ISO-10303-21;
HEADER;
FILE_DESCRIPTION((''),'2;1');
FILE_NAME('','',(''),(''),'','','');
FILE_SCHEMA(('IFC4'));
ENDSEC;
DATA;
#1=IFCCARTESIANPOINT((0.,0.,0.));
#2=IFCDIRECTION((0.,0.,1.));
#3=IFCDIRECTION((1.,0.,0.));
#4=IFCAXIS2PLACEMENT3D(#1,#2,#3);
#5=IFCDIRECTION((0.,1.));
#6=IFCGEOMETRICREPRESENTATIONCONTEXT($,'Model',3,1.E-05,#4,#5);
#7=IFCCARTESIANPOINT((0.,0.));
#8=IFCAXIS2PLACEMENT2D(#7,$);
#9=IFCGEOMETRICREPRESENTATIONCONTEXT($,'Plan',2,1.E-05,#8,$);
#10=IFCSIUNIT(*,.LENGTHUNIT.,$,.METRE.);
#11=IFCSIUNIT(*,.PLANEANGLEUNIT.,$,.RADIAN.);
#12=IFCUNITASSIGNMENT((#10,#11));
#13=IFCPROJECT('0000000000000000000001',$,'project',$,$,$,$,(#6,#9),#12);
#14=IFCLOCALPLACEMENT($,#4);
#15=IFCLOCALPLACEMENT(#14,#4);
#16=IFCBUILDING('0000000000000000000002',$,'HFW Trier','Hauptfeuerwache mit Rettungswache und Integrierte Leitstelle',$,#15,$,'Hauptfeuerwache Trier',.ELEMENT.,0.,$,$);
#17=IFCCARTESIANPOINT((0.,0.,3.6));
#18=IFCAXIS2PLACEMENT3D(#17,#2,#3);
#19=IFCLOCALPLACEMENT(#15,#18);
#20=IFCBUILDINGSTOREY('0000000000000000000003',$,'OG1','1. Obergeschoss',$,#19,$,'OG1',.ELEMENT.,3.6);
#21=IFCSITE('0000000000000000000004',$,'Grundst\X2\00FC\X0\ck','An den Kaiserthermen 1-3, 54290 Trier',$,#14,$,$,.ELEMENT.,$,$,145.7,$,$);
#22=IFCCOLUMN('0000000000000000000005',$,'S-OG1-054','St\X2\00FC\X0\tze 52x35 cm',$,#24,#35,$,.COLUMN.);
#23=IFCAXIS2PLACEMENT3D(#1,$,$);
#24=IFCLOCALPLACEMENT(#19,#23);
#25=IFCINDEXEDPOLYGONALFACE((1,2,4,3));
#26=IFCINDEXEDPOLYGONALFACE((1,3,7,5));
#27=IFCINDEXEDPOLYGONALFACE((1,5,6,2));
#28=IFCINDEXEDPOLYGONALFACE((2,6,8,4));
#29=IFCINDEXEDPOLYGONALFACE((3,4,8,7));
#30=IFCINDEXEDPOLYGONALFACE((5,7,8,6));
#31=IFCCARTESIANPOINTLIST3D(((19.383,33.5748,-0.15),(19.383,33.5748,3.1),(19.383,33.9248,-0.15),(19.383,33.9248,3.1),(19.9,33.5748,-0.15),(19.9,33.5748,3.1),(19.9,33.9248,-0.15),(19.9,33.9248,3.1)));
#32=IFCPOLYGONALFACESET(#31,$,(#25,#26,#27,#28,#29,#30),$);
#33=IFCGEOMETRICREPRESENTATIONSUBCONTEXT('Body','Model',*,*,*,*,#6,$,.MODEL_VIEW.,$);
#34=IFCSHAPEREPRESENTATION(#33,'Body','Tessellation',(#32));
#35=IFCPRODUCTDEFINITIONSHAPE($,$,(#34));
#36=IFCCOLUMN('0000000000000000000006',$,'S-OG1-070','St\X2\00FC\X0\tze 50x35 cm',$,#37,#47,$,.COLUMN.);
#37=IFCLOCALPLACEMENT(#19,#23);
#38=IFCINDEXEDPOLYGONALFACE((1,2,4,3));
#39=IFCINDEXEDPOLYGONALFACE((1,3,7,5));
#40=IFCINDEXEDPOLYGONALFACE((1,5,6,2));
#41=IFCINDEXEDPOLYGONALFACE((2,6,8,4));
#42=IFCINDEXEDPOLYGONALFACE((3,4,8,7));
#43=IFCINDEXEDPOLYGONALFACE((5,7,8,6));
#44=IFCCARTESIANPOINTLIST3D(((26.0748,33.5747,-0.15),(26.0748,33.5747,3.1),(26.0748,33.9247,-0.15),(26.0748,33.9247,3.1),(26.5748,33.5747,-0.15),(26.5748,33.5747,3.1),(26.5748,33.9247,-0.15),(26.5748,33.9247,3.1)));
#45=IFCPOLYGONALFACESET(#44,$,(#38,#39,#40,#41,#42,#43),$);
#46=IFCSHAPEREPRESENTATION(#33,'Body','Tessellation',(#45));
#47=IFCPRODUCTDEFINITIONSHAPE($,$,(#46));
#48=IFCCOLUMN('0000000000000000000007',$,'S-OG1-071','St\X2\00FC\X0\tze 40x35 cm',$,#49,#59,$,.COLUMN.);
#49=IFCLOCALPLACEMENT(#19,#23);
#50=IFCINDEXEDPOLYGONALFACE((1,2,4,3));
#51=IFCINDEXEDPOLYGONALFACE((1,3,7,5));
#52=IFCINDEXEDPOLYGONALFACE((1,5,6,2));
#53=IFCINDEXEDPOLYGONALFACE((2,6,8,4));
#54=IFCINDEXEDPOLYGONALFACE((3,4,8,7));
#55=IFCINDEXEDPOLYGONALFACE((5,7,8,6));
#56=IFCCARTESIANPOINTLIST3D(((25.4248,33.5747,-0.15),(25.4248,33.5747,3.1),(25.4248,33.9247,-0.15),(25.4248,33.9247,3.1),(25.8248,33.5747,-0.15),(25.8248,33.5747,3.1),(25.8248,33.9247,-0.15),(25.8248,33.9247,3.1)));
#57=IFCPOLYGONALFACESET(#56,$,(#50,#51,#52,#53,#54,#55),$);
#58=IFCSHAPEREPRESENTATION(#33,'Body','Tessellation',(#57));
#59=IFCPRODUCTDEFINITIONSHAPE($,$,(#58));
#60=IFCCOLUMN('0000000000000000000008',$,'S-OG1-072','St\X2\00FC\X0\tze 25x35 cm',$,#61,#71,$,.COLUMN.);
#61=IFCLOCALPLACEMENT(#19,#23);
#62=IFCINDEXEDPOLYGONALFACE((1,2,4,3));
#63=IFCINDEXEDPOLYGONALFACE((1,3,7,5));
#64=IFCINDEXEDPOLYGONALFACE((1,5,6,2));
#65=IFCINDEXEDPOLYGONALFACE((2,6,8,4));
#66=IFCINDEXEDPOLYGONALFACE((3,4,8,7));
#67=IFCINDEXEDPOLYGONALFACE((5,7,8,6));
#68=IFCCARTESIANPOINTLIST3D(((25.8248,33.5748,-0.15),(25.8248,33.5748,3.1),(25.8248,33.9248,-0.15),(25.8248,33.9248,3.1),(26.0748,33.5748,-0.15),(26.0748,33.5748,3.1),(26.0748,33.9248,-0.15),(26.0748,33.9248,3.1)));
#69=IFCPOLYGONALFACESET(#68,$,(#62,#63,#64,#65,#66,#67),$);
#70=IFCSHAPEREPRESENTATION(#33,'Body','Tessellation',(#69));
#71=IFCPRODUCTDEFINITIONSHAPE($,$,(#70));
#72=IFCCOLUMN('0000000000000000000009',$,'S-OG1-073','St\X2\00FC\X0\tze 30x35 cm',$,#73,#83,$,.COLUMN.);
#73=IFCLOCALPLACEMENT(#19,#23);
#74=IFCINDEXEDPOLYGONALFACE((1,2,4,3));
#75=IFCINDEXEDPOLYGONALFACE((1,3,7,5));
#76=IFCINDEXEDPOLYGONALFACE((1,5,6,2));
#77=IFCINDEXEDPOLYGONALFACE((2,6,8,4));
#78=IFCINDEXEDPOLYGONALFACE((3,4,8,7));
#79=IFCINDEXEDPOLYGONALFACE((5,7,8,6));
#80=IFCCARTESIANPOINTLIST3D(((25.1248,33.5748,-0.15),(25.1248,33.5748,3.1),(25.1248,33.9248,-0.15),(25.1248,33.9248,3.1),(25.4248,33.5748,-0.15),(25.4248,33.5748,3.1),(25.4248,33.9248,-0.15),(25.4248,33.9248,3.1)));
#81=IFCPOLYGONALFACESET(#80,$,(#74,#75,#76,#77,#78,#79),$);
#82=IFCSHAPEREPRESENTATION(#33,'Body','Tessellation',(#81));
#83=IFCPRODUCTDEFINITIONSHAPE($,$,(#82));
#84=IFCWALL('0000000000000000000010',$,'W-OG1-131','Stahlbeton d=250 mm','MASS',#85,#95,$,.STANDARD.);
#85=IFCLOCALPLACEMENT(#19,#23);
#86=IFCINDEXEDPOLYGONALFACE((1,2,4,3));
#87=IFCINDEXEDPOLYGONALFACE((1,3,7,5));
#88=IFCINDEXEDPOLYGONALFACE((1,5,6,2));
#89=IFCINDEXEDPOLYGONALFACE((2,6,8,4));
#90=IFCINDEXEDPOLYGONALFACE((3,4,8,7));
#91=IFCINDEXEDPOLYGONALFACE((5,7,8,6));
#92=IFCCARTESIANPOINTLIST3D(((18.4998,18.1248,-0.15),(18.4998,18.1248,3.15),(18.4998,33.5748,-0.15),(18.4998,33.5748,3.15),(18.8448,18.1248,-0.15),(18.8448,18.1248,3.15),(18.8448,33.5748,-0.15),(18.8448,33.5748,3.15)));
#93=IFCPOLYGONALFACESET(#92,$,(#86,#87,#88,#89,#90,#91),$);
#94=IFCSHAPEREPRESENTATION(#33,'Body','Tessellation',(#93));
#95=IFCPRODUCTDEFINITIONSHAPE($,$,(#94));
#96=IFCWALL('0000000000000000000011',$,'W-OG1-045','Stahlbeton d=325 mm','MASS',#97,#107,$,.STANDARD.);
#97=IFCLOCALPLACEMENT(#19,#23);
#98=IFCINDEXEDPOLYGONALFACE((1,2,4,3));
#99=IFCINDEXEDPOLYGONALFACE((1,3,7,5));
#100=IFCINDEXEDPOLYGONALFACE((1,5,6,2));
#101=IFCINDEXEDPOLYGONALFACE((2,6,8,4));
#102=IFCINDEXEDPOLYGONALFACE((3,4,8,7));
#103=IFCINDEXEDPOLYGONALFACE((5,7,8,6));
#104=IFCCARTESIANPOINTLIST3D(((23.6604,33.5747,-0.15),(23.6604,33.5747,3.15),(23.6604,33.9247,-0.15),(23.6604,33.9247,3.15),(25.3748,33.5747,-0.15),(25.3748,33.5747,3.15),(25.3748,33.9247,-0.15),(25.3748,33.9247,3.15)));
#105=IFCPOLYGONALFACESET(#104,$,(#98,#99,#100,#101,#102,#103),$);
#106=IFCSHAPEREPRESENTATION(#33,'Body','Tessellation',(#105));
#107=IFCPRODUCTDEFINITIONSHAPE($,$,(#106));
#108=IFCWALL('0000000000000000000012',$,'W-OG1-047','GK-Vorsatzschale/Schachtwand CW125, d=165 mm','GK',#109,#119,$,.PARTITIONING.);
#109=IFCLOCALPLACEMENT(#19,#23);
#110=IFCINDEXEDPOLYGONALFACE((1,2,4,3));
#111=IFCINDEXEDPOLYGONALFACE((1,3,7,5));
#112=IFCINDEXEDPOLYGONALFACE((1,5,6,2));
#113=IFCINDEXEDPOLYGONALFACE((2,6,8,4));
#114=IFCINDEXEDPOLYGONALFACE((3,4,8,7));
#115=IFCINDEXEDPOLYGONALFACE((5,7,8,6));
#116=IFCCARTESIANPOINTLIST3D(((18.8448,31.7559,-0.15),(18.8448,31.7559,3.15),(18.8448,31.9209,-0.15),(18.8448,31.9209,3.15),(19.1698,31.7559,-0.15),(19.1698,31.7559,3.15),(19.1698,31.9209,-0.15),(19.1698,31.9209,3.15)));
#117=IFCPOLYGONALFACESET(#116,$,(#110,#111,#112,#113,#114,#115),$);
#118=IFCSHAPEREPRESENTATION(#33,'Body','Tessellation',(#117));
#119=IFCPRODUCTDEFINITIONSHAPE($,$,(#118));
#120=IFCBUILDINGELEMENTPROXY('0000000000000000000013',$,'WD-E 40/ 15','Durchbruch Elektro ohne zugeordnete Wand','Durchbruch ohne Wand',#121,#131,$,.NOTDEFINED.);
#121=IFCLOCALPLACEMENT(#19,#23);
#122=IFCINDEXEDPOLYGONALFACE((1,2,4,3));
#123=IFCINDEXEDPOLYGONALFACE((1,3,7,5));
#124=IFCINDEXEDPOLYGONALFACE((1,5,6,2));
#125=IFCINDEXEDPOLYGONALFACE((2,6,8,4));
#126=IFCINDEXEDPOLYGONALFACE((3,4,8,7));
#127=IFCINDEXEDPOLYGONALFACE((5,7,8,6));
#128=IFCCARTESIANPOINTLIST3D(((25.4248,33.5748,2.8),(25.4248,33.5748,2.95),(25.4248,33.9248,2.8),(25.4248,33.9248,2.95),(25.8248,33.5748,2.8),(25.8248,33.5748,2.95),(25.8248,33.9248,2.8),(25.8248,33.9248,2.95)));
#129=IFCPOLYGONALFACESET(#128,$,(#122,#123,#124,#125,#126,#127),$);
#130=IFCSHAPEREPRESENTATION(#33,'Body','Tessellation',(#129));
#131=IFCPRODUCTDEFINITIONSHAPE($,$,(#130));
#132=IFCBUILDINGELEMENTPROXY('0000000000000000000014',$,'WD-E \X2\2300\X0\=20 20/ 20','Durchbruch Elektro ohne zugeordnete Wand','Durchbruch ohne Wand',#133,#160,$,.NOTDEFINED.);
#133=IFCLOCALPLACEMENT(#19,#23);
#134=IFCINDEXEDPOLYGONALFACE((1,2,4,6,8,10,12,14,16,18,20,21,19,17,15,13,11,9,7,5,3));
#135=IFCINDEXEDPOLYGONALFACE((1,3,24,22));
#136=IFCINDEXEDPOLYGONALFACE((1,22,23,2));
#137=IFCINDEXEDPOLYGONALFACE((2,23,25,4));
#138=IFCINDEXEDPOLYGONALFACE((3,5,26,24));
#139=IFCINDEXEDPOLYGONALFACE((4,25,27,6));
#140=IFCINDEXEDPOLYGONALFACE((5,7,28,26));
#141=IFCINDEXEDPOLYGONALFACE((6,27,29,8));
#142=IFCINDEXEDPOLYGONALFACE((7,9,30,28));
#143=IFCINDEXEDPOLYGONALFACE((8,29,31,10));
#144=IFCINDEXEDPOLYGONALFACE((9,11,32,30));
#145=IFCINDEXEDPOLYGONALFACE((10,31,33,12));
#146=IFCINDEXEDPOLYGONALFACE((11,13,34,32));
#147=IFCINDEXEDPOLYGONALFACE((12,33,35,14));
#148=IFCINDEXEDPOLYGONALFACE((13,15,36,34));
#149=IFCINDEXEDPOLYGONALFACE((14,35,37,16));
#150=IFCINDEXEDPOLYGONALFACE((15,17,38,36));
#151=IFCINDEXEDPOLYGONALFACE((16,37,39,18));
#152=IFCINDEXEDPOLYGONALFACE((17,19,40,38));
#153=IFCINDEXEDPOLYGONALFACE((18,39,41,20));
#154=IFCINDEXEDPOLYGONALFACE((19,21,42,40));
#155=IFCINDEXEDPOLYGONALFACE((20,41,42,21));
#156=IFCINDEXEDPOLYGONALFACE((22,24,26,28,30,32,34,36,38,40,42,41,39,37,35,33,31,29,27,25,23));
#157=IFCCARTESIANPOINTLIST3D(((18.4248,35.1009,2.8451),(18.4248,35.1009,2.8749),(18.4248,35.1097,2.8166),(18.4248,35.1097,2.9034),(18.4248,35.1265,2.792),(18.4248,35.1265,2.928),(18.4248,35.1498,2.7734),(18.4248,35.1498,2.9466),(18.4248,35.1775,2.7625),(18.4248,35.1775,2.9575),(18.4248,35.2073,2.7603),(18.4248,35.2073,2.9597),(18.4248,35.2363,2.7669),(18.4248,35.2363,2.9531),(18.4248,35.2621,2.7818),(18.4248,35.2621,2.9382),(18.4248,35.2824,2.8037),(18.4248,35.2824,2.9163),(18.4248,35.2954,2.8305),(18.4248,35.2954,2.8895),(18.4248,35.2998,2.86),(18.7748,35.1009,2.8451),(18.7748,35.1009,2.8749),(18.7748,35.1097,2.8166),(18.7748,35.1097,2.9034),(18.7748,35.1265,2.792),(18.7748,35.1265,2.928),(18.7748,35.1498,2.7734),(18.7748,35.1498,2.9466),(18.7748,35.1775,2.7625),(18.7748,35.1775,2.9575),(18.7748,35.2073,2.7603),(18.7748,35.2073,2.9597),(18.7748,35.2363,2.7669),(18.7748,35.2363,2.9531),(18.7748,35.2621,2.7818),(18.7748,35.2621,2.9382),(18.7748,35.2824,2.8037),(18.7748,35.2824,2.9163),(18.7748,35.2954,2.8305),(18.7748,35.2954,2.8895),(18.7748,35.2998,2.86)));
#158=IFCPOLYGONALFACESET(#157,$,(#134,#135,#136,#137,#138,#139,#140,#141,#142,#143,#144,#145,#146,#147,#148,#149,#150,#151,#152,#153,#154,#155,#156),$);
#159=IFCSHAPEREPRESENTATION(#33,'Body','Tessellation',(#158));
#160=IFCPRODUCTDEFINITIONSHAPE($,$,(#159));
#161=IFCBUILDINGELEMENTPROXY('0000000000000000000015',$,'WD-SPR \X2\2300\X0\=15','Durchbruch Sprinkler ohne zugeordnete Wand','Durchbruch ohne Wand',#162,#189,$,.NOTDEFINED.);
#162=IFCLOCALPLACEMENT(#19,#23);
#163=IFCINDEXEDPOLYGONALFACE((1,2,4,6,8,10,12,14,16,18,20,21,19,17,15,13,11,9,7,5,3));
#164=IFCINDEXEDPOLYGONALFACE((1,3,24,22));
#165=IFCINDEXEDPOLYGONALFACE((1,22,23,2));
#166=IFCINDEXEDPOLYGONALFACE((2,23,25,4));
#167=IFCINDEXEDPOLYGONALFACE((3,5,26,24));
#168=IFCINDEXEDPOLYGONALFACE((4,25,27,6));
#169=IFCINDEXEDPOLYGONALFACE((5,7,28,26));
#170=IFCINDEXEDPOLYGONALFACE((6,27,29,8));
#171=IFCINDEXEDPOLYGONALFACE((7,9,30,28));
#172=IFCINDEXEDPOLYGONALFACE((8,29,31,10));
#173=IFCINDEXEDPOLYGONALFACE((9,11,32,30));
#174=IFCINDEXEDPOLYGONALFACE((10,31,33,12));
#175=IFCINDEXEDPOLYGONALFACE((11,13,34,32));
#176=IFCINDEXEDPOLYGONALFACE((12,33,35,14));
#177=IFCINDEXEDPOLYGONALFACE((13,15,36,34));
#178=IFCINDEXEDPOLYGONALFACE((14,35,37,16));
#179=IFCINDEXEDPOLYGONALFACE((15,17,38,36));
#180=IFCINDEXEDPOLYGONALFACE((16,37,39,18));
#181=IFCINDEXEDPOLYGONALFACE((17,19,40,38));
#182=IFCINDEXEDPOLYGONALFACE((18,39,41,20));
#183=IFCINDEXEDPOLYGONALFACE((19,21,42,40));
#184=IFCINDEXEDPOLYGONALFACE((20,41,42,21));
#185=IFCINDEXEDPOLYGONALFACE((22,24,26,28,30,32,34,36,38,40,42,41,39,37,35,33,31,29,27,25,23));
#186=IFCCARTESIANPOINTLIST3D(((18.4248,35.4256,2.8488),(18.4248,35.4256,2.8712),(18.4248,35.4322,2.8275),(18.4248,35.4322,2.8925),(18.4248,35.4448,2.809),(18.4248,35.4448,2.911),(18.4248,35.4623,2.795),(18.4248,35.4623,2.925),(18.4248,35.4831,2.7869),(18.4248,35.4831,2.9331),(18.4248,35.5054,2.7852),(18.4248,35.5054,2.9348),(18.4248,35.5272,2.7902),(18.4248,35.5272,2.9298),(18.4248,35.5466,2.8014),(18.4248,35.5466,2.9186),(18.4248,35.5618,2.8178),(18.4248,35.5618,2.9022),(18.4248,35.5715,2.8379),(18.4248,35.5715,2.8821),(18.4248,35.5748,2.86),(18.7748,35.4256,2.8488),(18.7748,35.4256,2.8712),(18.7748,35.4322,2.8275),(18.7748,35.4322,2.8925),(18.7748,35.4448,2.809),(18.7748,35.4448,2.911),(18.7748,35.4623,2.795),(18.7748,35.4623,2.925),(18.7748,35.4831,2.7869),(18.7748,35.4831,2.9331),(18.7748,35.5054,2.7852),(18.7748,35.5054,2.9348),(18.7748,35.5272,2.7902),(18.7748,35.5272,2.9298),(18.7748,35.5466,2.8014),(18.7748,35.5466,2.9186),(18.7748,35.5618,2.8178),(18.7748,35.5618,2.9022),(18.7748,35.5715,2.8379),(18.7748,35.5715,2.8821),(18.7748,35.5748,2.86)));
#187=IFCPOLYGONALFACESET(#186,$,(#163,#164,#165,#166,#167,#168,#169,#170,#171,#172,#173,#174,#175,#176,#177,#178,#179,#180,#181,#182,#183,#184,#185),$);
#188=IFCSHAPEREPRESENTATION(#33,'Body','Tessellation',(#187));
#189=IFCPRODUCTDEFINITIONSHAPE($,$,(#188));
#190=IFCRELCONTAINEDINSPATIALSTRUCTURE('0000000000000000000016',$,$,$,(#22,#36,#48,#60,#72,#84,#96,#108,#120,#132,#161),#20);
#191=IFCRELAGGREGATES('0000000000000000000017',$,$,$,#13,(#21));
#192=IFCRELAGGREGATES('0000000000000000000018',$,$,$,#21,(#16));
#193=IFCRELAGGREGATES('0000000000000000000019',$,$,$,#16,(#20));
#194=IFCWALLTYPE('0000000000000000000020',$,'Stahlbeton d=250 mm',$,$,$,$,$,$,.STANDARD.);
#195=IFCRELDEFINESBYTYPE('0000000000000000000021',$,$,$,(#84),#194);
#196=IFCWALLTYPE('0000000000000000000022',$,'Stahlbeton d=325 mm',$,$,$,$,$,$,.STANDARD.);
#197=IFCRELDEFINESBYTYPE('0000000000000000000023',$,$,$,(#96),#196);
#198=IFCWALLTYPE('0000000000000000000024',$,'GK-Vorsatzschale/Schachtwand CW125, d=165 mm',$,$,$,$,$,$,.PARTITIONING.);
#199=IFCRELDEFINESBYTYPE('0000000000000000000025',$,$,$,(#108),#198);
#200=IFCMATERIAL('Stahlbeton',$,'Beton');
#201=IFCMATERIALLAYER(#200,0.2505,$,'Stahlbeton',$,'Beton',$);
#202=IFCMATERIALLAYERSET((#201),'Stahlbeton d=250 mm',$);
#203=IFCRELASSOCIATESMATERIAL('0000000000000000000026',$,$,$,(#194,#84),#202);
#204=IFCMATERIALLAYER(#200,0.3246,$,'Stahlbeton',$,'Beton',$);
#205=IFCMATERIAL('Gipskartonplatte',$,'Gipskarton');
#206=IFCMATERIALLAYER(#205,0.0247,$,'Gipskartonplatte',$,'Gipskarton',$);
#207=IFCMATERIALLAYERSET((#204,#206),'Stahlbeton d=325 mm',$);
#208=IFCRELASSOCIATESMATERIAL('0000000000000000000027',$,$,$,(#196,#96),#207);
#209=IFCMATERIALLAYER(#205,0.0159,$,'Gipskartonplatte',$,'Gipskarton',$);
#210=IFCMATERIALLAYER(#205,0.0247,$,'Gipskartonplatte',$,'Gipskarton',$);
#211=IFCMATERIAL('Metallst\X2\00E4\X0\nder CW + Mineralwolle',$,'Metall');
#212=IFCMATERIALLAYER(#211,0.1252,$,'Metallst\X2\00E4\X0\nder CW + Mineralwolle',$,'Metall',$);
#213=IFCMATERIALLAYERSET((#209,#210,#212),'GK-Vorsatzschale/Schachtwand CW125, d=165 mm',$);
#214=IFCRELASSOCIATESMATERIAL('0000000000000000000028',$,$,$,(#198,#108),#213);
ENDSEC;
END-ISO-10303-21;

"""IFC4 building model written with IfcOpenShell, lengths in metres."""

from ifc_helpers import new_model, si_unit, direction, frame, frame_2d, origin_with_axes, origin_2d, place, context, subcontext, project, spatial, rectangle, circle, extrude, material, layer, layer_set, layer_usage, type_object, element, save


model = new_model("IFC4")

# Units and contexts
model_context = context("Model", 3, precision=1e-05, world=origin_with_axes(), true_north=direction((0.0, 1.0)))
plan_context = context("Plan", 2, precision=1e-05, world=origin_2d())
body_context = subcontext(model_context, "Body", "Model", "MODEL_VIEW")
ifc_project = project(units=[si_unit("LENGTHUNIT", "METRE"), si_unit("PLANEANGLEUNIT", "RADIAN")], contexts=[model_context, plan_context])

# Site, building, storey
site_placement = place(None, origin_with_axes())
site = spatial("IfcSite", under=ifc_project, at=site_placement, Name="Grundstück", Description="An den Kaiserthermen 1-3, 54290 Trier", CompositionType="ELEMENT", RefElevation=145.7)
building_placement = place(site_placement, origin_with_axes())
building = spatial("IfcBuilding", under=site, at=building_placement, Name="HFW Trier", Description="Hauptfeuerwache mit Rettungswache und Integrierte Leitstelle", LongName="Hauptfeuerwache Trier", CompositionType="ELEMENT", ElevationOfRefHeight=0.0)
storey_placement = place(building_placement, frame((0.0, 0.0, 3.6), z_axis=(0.0, 0.0, 1.0), x_axis=(1.0, 0.0, 0.0)))
storey = spatial("IfcBuildingStorey", under=building, at=storey_placement, Name="OG1", Description="1. Obergeschoss", LongName="OG1", CompositionType="ELEMENT", Elevation=3.6)

# Columns
column_1_placement = place(storey_placement, frame((19.383, 33.7498, -0.15), z_axis=(0.0, 0.0, 1.0), x_axis=(1.0, 0.0, 0.0)))
element("IfcColumn", 1, at=column_1_placement, inside=storey, Name="S-OG1-054", Description="Stütze 52x35 cm", PredefinedType="COLUMN", context=body_context, shape_type="SweptSolid", body=[
    extrude(rectangle(XDim=0.517, YDim=0.35, at=frame_2d((0.2585, 0.0))), origin_with_axes(), (0.0, 0.0, 1.0), 3.25),
])
column_2_placement = place(storey_placement, frame((26.0748, 33.7497, -0.15), z_axis=(0.0, 0.0, 1.0), x_axis=(1.0, 0.0, 0.0)))
element("IfcColumn", 2, at=column_2_placement, inside=storey, Name="S-OG1-070", Description="Stütze 50x35 cm", PredefinedType="COLUMN", context=body_context, shape_type="SweptSolid", body=[
    extrude(rectangle(XDim=0.5, YDim=0.35, at=frame_2d((0.25, 0.0))), origin_with_axes(), (0.0, 0.0, 1.0), 3.25),
])
column_3_placement = place(storey_placement, frame((25.4248, 33.7497, -0.15), z_axis=(0.0, 0.0, 1.0), x_axis=(1.0, 0.0, 0.0)))
element("IfcColumn", 3, at=column_3_placement, inside=storey, Name="S-OG1-071", Description="Stütze 40x35 cm", PredefinedType="COLUMN", context=body_context, shape_type="SweptSolid", body=[
    extrude(rectangle(XDim=0.4, YDim=0.35, at=frame_2d((0.2, 0.0))), origin_with_axes(), (0.0, 0.0, 1.0), 3.25),
])
column_4_placement = place(storey_placement, frame((25.8248, 33.7498, -0.15), z_axis=(0.0, 0.0, 1.0), x_axis=(1.0, 0.0, 0.0)))
element("IfcColumn", 4, at=column_4_placement, inside=storey, Name="S-OG1-072", Description="Stütze 25x35 cm", PredefinedType="COLUMN", context=body_context, shape_type="SweptSolid", body=[
    extrude(rectangle(XDim=0.25, YDim=0.35, at=frame_2d((0.125, 0.0))), origin_with_axes(), (0.0, 0.0, 1.0), 3.25),
])
column_5_placement = place(storey_placement, frame((25.1248, 33.7498, -0.15), z_axis=(0.0, 0.0, 1.0), x_axis=(1.0, 0.0, 0.0)))
element("IfcColumn", 5, at=column_5_placement, inside=storey, Name="S-OG1-073", Description="Stütze 30x35 cm", PredefinedType="COLUMN", context=body_context, shape_type="SweptSolid", body=[
    extrude(rectangle(XDim=0.3, YDim=0.35, at=frame_2d((0.15, 0.0))), origin_with_axes(), (0.0, 0.0, 1.0), 3.25),
])

# Wall
ifc_material_1 = material(Name="Stahlbeton", Category="Beton")
ifc_layer_1 = layer(ifc_material_1, 0.2505, Name="Stahlbeton", Category="Beton")
ifc_layer_set_1 = layer_set([ifc_layer_1], Name="Stahlbeton d=250 mm")
ifc_layer_usage_1 = layer_usage(ifc_layer_set_1, "AXIS2", "POSITIVE", -0.1725)
wall_type_1 = type_object("IfcWallType", Name="Stahlbeton d=250 mm", PredefinedType="STANDARD", material=ifc_layer_set_1)
wall_1_placement = place(storey_placement, frame((18.6723, 33.5748, -0.15), z_axis=(0.0, 0.0, 1.0), x_axis=(0.0, -1.0, 0.0)))
element("IfcWall", 6, at=wall_1_placement, inside=storey, type_object=wall_type_1, material=ifc_layer_usage_1, Name="W-OG1-131", Description="Stahlbeton d=250 mm", ObjectType="MASS", PredefinedType="STANDARD", context=body_context, shape_type="SweptSolid", body=[
    extrude(rectangle(XDim=15.45, YDim=0.345, at=frame_2d((7.725, 0.0))), origin_with_axes(), (0.0, 0.0, 1.0), 3.3),
])

# Walls
ifc_layer_2 = layer(ifc_material_1, 0.3246, Name="Stahlbeton", Category="Beton")
ifc_material_2 = material(Name="Gipskartonplatte", Category="Gipskarton")
ifc_layer_3 = layer(ifc_material_2, 0.0247, Name="Gipskartonplatte", Category="Gipskarton")
ifc_layer_set_2 = layer_set([ifc_layer_2, ifc_layer_3], Name="Stahlbeton d=325 mm")
ifc_layer_usage_2 = layer_usage(ifc_layer_set_2, "AXIS2", "POSITIVE", -0.175)
wall_type_2 = type_object("IfcWallType", Name="Stahlbeton d=325 mm", PredefinedType="STANDARD", material=ifc_layer_set_2)
wall_2_placement = place(storey_placement, frame((23.6604, 33.7497, -0.15), z_axis=(0.0, 0.0, 1.0), x_axis=(1.0, 0.0, 0.0)))
element("IfcWall", 7, at=wall_2_placement, inside=storey, type_object=wall_type_2, material=ifc_layer_usage_2, Name="W-OG1-045", Description="Stahlbeton d=325 mm", ObjectType="MASS", PredefinedType="STANDARD", context=body_context, shape_type="SweptSolid", body=[
    extrude(rectangle(XDim=1.7144, YDim=0.35, at=frame_2d((0.8572, 0.0))), origin_with_axes(), (0.0, 0.0, 1.0), 3.3),
])
ifc_layer_4 = layer(ifc_material_2, 0.0159, Name="Gipskartonplatte", Category="Gipskarton")
ifc_layer_5 = layer(ifc_material_2, 0.0247, Name="Gipskartonplatte", Category="Gipskarton")
ifc_material_3 = material(Name="Metallständer CW + Mineralwolle", Category="Metall")
ifc_layer_6 = layer(ifc_material_3, 0.1252, Name="Metallständer CW + Mineralwolle", Category="Metall")
ifc_layer_set_3 = layer_set([ifc_layer_4, ifc_layer_5, ifc_layer_6], Name="GK-Vorsatzschale/Schachtwand CW125, d=165 mm")
ifc_layer_usage_3 = layer_usage(ifc_layer_set_3, "AXIS2", "POSITIVE", -0.0825)
wall_type_3 = type_object("IfcWallType", Name="GK-Vorsatzschale/Schachtwand CW125, d=165 mm", PredefinedType="PARTITIONING", material=ifc_layer_set_3)
wall_3_placement = place(storey_placement, frame((18.8448, 31.8384, -0.15), z_axis=(0.0, 0.0, 1.0), x_axis=(1.0, 0.0, 0.0)))
element("IfcWall", 8, at=wall_3_placement, inside=storey, type_object=wall_type_3, material=ifc_layer_usage_3, Name="W-OG1-047", Description="GK-Vorsatzschale/Schachtwand CW125, d=165 mm", ObjectType="GK", PredefinedType="PARTITIONING", context=body_context, shape_type="SweptSolid", body=[
    extrude(rectangle(XDim=0.325, YDim=0.165, at=frame_2d((0.1625, 0.0))), origin_with_axes(), (0.0, 0.0, 1.0), 3.3),
])

# Building element proxies
proxy_1_placement = place(storey_placement, frame((25.6248, 33.7498, 2.8), z_axis=(0.0, 0.0, 1.0), x_axis=(1.0, 0.0, 0.0)))
element("IfcBuildingElementProxy", 9, at=proxy_1_placement, inside=storey, Name="WD-E 40/ 15", Description="Durchbruch Elektro ohne zugeordnete Wand", ObjectType="Durchbruch ohne Wand", PredefinedType="NOTDEFINED", context=body_context, shape_type="SweptSolid", body=[
    extrude(rectangle(XDim=0.4, YDim=0.35, at=origin_2d()), origin_with_axes(), (0.0, 0.0, 1.0), 0.15),
])
proxy_2_placement = place(storey_placement, frame((18.5998, 35.1998, 2.76), z_axis=(0.0, 0.0, 1.0), x_axis=(0.0, 1.0, 0.0)))
element("IfcBuildingElementProxy", 10, at=proxy_2_placement, inside=storey, Name="WD-E ⌀=20 20/ 20", Description="Durchbruch Elektro ohne zugeordnete Wand", ObjectType="Durchbruch ohne Wand", PredefinedType="NOTDEFINED", context=body_context, shape_type="SweptSolid", body=[
    extrude(circle(Radius=0.1, at=origin_2d()), frame((0.0, -0.175, 0.1), z_axis=(0.0, 1.0, 0.0), x_axis=(1.0, 0.0, 0.0)), (0.0, 0.0, 1.0), 0.35),
])
for number, where, z_axis, x_axis, name in (
    (11, (18.5998, 35.4998, 2.785), (0.0, 0.0, 1.0), (0.0, 1.0, 0.0), "WD-SPR ⌀=15"),
):
    element("IfcBuildingElementProxy", number, at=place(storey_placement, frame(where, z_axis=z_axis, x_axis=x_axis)), inside=storey, Name=name, Description="Durchbruch Sprinkler ohne zugeordnete Wand", ObjectType="Durchbruch ohne Wand", PredefinedType="NOTDEFINED", context=body_context, shape_type="SweptSolid", body=[
        extrude(circle(Radius=0.075, at=origin_2d()), frame((0.0, -0.175, 0.075), z_axis=(0.0, 1.0, 0.0), x_axis=(1.0, 0.0, 0.0)), (0.0, 0.0, 1.0), 0.35),
    ])

save(model, "model.ifc")
